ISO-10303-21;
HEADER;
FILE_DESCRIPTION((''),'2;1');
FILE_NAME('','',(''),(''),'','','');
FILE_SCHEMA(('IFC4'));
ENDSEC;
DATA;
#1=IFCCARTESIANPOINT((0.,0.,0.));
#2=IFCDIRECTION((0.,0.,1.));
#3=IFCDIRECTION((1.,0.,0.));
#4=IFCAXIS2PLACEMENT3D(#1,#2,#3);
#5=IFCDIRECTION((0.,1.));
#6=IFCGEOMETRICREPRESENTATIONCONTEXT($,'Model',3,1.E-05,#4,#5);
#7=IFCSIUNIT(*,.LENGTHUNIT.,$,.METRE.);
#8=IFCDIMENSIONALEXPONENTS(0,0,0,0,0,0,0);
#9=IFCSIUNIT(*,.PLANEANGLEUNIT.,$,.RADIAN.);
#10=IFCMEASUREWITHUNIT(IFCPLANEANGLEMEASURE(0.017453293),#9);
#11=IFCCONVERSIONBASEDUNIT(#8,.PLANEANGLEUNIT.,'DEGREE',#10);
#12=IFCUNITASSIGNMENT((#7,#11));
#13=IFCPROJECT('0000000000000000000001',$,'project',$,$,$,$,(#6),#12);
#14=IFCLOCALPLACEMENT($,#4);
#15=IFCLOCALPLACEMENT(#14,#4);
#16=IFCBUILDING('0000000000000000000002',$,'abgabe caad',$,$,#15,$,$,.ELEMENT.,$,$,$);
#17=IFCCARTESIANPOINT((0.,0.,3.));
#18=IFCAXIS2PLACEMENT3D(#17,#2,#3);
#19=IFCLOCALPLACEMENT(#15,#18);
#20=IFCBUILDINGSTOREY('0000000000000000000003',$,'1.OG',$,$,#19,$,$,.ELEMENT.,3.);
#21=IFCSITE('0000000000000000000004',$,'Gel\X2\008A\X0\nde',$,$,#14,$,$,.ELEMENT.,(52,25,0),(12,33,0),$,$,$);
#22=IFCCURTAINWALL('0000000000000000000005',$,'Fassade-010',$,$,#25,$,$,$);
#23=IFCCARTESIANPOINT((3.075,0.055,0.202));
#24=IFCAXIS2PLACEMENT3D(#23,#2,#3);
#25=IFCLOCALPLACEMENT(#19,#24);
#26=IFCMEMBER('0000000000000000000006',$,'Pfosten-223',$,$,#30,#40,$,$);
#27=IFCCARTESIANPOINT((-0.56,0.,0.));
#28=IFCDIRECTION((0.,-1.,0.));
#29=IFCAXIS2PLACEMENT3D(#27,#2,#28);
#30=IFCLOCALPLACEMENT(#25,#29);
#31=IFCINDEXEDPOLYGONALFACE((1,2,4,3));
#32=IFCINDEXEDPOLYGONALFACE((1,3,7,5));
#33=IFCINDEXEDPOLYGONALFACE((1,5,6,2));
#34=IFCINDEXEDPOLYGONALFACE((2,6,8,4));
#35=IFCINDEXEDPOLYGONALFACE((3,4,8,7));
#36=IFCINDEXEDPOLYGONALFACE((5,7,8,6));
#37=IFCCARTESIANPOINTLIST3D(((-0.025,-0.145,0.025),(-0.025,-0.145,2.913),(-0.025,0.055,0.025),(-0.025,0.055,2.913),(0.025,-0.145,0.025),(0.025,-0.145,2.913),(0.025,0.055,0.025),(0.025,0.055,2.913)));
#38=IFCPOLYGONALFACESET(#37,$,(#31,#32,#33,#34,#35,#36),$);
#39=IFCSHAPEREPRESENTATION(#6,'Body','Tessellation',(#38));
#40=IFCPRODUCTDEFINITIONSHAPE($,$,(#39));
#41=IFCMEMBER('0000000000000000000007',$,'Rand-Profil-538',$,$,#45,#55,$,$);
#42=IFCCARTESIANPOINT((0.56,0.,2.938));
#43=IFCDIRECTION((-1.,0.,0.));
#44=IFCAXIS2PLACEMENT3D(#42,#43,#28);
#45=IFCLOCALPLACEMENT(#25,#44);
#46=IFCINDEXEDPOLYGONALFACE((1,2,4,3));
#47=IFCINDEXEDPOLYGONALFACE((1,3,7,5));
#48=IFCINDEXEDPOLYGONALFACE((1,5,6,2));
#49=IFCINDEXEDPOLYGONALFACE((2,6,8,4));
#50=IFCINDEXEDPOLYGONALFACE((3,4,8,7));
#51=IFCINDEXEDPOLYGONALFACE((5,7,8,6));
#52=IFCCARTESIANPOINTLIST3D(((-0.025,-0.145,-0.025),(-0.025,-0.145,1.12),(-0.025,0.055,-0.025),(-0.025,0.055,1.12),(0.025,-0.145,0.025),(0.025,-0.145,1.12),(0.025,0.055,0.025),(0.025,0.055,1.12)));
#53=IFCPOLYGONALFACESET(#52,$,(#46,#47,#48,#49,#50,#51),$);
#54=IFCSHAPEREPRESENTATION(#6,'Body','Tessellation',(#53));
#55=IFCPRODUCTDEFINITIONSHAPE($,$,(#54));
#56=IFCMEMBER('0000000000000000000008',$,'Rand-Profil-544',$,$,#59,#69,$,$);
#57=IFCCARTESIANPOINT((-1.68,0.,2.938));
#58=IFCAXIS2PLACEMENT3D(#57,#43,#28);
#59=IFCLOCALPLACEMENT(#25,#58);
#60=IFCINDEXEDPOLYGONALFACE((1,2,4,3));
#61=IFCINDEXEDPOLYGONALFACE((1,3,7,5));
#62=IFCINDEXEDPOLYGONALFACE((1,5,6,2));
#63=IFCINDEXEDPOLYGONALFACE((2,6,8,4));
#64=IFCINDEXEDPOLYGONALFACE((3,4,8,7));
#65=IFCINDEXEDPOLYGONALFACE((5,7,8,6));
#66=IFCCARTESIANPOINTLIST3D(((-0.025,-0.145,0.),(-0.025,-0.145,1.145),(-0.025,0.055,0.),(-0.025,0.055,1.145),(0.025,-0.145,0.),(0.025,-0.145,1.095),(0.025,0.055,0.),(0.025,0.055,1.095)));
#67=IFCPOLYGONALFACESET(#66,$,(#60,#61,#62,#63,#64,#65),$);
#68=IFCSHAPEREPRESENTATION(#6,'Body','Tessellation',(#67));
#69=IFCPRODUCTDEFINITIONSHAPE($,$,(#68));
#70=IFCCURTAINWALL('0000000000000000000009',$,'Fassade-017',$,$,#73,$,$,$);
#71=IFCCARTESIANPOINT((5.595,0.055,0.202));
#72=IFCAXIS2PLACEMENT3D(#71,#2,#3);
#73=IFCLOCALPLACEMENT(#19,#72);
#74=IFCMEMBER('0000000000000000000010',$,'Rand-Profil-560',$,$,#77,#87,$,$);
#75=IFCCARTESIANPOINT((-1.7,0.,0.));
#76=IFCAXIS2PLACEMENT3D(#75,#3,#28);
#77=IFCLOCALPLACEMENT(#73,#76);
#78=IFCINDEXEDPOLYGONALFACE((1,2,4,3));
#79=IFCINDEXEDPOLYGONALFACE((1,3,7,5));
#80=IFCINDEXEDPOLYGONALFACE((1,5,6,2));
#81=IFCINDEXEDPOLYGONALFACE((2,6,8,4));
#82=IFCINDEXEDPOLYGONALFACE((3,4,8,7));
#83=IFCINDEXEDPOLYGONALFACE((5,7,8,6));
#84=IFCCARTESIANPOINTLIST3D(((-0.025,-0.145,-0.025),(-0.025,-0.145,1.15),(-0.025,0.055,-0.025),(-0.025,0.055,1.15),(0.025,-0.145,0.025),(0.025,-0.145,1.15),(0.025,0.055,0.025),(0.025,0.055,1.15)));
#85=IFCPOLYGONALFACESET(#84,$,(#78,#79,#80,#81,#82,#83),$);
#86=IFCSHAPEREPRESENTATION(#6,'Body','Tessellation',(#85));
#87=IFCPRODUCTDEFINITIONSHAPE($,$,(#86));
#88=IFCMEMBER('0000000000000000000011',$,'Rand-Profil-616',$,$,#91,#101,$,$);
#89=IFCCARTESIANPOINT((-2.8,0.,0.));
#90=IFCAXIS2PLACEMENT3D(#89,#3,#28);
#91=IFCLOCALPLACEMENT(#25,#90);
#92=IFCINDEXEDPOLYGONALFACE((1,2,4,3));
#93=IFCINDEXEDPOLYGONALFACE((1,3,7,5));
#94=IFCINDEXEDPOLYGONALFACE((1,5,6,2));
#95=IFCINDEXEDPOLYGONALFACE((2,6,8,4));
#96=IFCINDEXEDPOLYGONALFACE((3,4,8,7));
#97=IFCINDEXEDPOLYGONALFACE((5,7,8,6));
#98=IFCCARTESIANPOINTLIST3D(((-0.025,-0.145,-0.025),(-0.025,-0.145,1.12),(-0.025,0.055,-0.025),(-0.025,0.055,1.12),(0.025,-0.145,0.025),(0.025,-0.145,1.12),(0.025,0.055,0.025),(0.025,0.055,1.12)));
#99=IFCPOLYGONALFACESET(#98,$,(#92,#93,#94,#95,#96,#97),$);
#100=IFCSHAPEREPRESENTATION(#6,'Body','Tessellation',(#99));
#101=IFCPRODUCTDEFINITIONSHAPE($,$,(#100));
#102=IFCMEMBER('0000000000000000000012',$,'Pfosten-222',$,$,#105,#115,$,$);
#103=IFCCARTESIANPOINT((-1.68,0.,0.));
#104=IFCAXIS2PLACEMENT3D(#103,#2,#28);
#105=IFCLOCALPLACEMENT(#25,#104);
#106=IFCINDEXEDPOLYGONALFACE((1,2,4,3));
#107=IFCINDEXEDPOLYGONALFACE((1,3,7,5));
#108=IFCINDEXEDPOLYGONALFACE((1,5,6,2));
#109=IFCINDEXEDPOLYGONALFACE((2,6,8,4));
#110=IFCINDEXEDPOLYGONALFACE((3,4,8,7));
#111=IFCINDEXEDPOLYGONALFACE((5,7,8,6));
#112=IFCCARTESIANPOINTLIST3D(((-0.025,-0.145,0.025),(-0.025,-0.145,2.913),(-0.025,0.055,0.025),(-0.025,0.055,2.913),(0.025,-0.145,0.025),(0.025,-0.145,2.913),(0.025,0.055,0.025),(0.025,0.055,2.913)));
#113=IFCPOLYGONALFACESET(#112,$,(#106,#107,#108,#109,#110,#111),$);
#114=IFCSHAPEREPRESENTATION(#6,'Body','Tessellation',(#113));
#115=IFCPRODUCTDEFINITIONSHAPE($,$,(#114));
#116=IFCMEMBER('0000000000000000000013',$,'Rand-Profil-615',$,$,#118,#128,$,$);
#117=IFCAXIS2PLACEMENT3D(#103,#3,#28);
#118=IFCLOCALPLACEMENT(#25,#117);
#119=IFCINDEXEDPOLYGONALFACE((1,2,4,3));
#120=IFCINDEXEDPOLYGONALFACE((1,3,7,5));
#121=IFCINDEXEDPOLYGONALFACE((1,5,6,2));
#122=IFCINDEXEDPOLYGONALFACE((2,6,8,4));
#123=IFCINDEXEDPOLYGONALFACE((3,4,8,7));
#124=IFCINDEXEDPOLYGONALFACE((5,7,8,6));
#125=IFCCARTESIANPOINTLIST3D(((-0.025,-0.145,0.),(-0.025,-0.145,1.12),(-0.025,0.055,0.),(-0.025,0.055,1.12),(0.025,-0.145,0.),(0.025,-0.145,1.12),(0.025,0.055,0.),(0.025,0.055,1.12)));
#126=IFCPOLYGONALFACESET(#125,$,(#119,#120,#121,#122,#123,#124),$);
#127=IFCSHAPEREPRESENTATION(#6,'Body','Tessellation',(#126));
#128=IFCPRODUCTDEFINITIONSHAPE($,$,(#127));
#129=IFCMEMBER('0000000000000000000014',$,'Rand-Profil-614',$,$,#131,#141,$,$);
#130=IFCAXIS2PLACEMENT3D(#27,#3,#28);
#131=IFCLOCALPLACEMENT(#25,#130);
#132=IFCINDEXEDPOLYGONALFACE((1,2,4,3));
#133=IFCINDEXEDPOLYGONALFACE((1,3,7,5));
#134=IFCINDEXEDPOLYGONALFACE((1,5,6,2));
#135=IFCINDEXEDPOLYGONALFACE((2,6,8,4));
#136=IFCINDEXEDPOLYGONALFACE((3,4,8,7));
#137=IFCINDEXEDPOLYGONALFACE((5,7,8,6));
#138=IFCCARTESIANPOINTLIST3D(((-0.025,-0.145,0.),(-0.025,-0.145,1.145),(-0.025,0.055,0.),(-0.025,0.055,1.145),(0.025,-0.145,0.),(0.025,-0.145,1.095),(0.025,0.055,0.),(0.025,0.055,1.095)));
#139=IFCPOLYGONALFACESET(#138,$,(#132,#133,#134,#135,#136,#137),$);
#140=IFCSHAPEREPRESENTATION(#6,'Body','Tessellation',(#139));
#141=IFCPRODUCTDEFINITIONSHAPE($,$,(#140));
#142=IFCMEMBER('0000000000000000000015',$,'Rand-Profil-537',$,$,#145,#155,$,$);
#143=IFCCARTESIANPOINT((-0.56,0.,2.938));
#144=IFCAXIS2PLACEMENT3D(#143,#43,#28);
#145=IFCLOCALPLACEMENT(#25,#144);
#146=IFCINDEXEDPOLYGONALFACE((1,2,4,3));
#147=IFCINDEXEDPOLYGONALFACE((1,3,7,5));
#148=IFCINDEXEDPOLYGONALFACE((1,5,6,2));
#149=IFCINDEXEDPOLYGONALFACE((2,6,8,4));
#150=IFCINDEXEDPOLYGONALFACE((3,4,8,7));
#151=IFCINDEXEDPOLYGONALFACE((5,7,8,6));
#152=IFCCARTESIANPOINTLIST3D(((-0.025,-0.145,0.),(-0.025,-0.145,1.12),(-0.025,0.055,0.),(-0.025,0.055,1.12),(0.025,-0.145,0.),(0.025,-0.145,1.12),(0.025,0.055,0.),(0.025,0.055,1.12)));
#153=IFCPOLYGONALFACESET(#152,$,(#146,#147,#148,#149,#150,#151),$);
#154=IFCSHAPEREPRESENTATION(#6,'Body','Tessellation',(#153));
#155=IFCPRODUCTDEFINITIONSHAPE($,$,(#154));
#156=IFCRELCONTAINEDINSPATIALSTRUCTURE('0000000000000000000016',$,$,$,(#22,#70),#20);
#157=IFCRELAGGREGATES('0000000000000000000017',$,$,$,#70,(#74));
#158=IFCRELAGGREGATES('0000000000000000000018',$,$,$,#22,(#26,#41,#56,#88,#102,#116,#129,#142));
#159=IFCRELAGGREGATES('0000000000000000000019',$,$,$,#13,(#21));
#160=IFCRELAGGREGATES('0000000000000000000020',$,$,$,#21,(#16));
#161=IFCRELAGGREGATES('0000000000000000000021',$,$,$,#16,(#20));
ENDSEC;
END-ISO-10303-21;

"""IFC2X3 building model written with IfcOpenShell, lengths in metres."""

from ifc_helpers import new_model, entity, si_unit, converted_unit, direction, frame, origin_with_axes, place, context, project, spatial, polyline, outline, extrude, clip, halfspace, element, aggregate, save


model = new_model("IFC2X3")

# Units and contexts
model_context = context("Model", 3, precision=1e-05, world=origin_with_axes(), true_north=direction((0.0, 1.0)))
ifc_project = project(units=[si_unit("LENGTHUNIT", "METRE"), converted_unit("PLANEANGLEUNIT", "DEGREE", entity("IfcPlaneAngleMeasure", 0.017453293), si_unit("PLANEANGLEUNIT", "RADIAN"), dimensions=[0, 0, 0, 0, 0, 0, 0])], contexts=[model_context])

# Site, building, storey
site_placement = place(None, origin_with_axes())
site = spatial("IfcSite", under=ifc_project, at=site_placement, Name="Gel\u008ande", CompositionType="ELEMENT", RefLatitude=(52, 25, 0), RefLongitude=(12, 33, 0))
building_placement = place(site_placement, origin_with_axes())
building = spatial("IfcBuilding", under=site, at=building_placement, Name="abgabe caad", CompositionType="ELEMENT")
storey_placement = place(building_placement, frame((0.0, 0.0, 3.0), z_axis=(0.0, 0.0, 1.0), x_axis=(1.0, 0.0, 0.0)))
storey = spatial("IfcBuildingStorey", under=building, at=storey_placement, Name="1.OG", CompositionType="ELEMENT", Elevation=3.0)

# Curtain walls, members
curtain_wall_1_placement = place(storey_placement, frame((3.075, 0.055, 0.202), z_axis=(0.0, 0.0, 1.0), x_axis=(1.0, 0.0, 0.0)))
curtain_wall_1 = element("IfcCurtainWall", 1, at=curtain_wall_1_placement, inside=storey, Name="Fassade-010")
member_1_placement = place(curtain_wall_1_placement, frame((-0.56, 0.0, 0.0), z_axis=(0.0, 0.0, 1.0), x_axis=(0.0, -1.0, 0.0)))
member_1 = element("IfcMember", 2, at=member_1_placement, Name="Pfosten-223", context=model_context, shape_type="SweptSolid", body=[
    extrude(outline(polyline([(-0.145, -0.025), (0.055, -0.025), (0.055, 0.025), (-0.145, 0.025), (-0.145, -0.025)])), frame((0.0, 0.0, 0.025), z_axis=(0.0, 0.0, 1.0), x_axis=(0.0, 1.0, 0.0)), (0.0, 0.0, 1.0), 2.888),
])
member_2_placement = place(curtain_wall_1_placement, frame((0.56, 0.0, 2.938), z_axis=(-1.0, 0.0, 0.0), x_axis=(0.0, -1.0, 0.0)))
member_2 = element("IfcMember", 3, at=member_2_placement, Name="Rand-Profil-538", context=model_context, shape_type="Clipping", body=[
    clip(extrude(outline(polyline([(-0.025, 0.145), (-0.025, -0.055), (0.025, -0.055), (0.025, 0.145), (-0.025, 0.145)])), frame((0.0, 0.0, -0.025), z_axis=(0.0, 0.0, 1.0), x_axis=(-1.0, 0.0, 0.0)), (0.0, 0.0, 1.0), 1.145), halfspace(frame((0.0, 0.0, 0.0), z_axis=(-0.707107, 0.0, 0.707107), x_axis=(-0.707107, 0.0, -0.707107)), True)),
])
member_3_placement = place(curtain_wall_1_placement, frame((-1.68, 0.0, 2.938), z_axis=(-1.0, 0.0, 0.0), x_axis=(0.0, -1.0, 0.0)))
member_3 = element("IfcMember", 4, at=member_3_placement, Name="Rand-Profil-544", context=model_context, shape_type="Clipping", body=[
    clip(extrude(outline(polyline([(-0.025, 0.145), (-0.025, -0.055), (0.025, -0.055), (0.025, 0.145), (-0.025, 0.145)])), frame((0.0, 0.0, 0.0), z_axis=(0.0, 0.0, 1.0), x_axis=(-1.0, 0.0, 0.0)), (0.0, 0.0, 1.0), 1.145), halfspace(frame((0.56, 0.0, 0.56), z_axis=(-0.707107, 0.0, -0.707107), x_axis=(0.707107, 0.0, -0.707107)), True)),
])
curtain_wall_2_placement = place(storey_placement, frame((5.595, 0.055, 0.202), z_axis=(0.0, 0.0, 1.0), x_axis=(1.0, 0.0, 0.0)))
curtain_wall_2 = element("IfcCurtainWall", 5, at=curtain_wall_2_placement, inside=storey, Name="Fassade-017")
member_4_placement = place(curtain_wall_2_placement, frame((-1.7, 0.0, 0.0), z_axis=(1.0, 0.0, 0.0), x_axis=(0.0, -1.0, 0.0)))
member_4 = element("IfcMember", 6, at=member_4_placement, Name="Rand-Profil-560", context=model_context, shape_type="Clipping", body=[
    clip(extrude(outline(polyline([(0.025, -0.145), (0.025, 0.055), (-0.025, 0.055), (-0.025, -0.145), (0.025, -0.145)])), frame((0.0, 0.0, -0.025), z_axis=(0.0, 0.0, 1.0), x_axis=(1.0, 0.0, 0.0)), (0.0, 0.0, 1.0), 1.175), halfspace(frame((0.0, 0.0, 0.0), z_axis=(-0.707107, 0.0, 0.707107), x_axis=(-0.707107, 0.0, -0.707107)), True)),
])

# Members
member_5_placement = place(curtain_wall_1_placement, frame((-2.8, 0.0, 0.0), z_axis=(1.0, 0.0, 0.0), x_axis=(0.0, -1.0, 0.0)))
member_5 = element("IfcMember", 7, at=member_5_placement, Name="Rand-Profil-616", context=model_context, shape_type="Clipping", body=[
    clip(extrude(outline(polyline([(0.025, -0.145), (0.025, 0.055), (-0.025, 0.055), (-0.025, -0.145), (0.025, -0.145)])), frame((0.0, 0.0, -0.025), z_axis=(0.0, 0.0, 1.0), x_axis=(1.0, 0.0, 0.0)), (0.0, 0.0, 1.0), 1.145), halfspace(frame((0.0, 0.0, 0.0), z_axis=(-0.707107, 0.0, 0.707107), x_axis=(-0.707107, 0.0, -0.707107)), True)),
])
member_6_placement = place(curtain_wall_1_placement, frame((-1.68, 0.0, 0.0), z_axis=(0.0, 0.0, 1.0), x_axis=(0.0, -1.0, 0.0)))
member_6 = element("IfcMember", 8, at=member_6_placement, Name="Pfosten-222", context=model_context, shape_type="SweptSolid", body=[
    extrude(outline(polyline([(-0.145, -0.025), (0.055, -0.025), (0.055, 0.025), (-0.145, 0.025), (-0.145, -0.025)])), frame((0.0, 0.0, 0.025), z_axis=(0.0, 0.0, 1.0), x_axis=(0.0, 1.0, 0.0)), (0.0, 0.0, 1.0), 2.888),
])
member_7_placement = place(curtain_wall_1_placement, frame((-1.68, 0.0, 0.0), z_axis=(1.0, 0.0, 0.0), x_axis=(0.0, -1.0, 0.0)))
member_7 = element("IfcMember", 9, at=member_7_placement, Name="Rand-Profil-615", context=model_context, shape_type="SweptSolid", body=[
    extrude(outline(polyline([(0.025, -0.145), (0.025, 0.055), (-0.025, 0.055), (-0.025, -0.145), (0.025, -0.145)])), origin_with_axes(), (0.0, 0.0, 1.0), 1.12),
])
member_8_placement = place(curtain_wall_1_placement, frame((-0.56, 0.0, 0.0), z_axis=(1.0, 0.0, 0.0), x_axis=(0.0, -1.0, 0.0)))
member_8 = element("IfcMember", 10, at=member_8_placement, Name="Rand-Profil-614", context=model_context, shape_type="Clipping", body=[
    clip(extrude(outline(polyline([(0.025, -0.145), (0.025, 0.055), (-0.025, 0.055), (-0.025, -0.145), (0.025, -0.145)])), origin_with_axes(), (0.0, 0.0, 1.0), 1.145), halfspace(frame((0.56, 0.0, 0.56), z_axis=(-0.707107, 0.0, -0.707107), x_axis=(0.707107, 0.0, -0.707107)), True)),
])
member_9_placement = place(curtain_wall_1_placement, frame((-0.56, 0.0, 2.938), z_axis=(-1.0, 0.0, 0.0), x_axis=(0.0, -1.0, 0.0)))
member_9 = element("IfcMember", 11, at=member_9_placement, Name="Rand-Profil-537", context=model_context, shape_type="SweptSolid", body=[
    extrude(outline(polyline([(-0.025, 0.145), (-0.025, -0.055), (0.025, -0.055), (0.025, 0.145), (-0.025, 0.145)])), frame((0.0, 0.0, 0.0), z_axis=(0.0, 0.0, 1.0), x_axis=(-1.0, 0.0, 0.0)), (0.0, 0.0, 1.0), 1.12),
])

aggregate(curtain_wall_2, [member_4])

aggregate(curtain_wall_1, [member_1, member_2, member_3, member_5, member_6, member_7, member_8, member_9])

save(model, "model.ifc")
